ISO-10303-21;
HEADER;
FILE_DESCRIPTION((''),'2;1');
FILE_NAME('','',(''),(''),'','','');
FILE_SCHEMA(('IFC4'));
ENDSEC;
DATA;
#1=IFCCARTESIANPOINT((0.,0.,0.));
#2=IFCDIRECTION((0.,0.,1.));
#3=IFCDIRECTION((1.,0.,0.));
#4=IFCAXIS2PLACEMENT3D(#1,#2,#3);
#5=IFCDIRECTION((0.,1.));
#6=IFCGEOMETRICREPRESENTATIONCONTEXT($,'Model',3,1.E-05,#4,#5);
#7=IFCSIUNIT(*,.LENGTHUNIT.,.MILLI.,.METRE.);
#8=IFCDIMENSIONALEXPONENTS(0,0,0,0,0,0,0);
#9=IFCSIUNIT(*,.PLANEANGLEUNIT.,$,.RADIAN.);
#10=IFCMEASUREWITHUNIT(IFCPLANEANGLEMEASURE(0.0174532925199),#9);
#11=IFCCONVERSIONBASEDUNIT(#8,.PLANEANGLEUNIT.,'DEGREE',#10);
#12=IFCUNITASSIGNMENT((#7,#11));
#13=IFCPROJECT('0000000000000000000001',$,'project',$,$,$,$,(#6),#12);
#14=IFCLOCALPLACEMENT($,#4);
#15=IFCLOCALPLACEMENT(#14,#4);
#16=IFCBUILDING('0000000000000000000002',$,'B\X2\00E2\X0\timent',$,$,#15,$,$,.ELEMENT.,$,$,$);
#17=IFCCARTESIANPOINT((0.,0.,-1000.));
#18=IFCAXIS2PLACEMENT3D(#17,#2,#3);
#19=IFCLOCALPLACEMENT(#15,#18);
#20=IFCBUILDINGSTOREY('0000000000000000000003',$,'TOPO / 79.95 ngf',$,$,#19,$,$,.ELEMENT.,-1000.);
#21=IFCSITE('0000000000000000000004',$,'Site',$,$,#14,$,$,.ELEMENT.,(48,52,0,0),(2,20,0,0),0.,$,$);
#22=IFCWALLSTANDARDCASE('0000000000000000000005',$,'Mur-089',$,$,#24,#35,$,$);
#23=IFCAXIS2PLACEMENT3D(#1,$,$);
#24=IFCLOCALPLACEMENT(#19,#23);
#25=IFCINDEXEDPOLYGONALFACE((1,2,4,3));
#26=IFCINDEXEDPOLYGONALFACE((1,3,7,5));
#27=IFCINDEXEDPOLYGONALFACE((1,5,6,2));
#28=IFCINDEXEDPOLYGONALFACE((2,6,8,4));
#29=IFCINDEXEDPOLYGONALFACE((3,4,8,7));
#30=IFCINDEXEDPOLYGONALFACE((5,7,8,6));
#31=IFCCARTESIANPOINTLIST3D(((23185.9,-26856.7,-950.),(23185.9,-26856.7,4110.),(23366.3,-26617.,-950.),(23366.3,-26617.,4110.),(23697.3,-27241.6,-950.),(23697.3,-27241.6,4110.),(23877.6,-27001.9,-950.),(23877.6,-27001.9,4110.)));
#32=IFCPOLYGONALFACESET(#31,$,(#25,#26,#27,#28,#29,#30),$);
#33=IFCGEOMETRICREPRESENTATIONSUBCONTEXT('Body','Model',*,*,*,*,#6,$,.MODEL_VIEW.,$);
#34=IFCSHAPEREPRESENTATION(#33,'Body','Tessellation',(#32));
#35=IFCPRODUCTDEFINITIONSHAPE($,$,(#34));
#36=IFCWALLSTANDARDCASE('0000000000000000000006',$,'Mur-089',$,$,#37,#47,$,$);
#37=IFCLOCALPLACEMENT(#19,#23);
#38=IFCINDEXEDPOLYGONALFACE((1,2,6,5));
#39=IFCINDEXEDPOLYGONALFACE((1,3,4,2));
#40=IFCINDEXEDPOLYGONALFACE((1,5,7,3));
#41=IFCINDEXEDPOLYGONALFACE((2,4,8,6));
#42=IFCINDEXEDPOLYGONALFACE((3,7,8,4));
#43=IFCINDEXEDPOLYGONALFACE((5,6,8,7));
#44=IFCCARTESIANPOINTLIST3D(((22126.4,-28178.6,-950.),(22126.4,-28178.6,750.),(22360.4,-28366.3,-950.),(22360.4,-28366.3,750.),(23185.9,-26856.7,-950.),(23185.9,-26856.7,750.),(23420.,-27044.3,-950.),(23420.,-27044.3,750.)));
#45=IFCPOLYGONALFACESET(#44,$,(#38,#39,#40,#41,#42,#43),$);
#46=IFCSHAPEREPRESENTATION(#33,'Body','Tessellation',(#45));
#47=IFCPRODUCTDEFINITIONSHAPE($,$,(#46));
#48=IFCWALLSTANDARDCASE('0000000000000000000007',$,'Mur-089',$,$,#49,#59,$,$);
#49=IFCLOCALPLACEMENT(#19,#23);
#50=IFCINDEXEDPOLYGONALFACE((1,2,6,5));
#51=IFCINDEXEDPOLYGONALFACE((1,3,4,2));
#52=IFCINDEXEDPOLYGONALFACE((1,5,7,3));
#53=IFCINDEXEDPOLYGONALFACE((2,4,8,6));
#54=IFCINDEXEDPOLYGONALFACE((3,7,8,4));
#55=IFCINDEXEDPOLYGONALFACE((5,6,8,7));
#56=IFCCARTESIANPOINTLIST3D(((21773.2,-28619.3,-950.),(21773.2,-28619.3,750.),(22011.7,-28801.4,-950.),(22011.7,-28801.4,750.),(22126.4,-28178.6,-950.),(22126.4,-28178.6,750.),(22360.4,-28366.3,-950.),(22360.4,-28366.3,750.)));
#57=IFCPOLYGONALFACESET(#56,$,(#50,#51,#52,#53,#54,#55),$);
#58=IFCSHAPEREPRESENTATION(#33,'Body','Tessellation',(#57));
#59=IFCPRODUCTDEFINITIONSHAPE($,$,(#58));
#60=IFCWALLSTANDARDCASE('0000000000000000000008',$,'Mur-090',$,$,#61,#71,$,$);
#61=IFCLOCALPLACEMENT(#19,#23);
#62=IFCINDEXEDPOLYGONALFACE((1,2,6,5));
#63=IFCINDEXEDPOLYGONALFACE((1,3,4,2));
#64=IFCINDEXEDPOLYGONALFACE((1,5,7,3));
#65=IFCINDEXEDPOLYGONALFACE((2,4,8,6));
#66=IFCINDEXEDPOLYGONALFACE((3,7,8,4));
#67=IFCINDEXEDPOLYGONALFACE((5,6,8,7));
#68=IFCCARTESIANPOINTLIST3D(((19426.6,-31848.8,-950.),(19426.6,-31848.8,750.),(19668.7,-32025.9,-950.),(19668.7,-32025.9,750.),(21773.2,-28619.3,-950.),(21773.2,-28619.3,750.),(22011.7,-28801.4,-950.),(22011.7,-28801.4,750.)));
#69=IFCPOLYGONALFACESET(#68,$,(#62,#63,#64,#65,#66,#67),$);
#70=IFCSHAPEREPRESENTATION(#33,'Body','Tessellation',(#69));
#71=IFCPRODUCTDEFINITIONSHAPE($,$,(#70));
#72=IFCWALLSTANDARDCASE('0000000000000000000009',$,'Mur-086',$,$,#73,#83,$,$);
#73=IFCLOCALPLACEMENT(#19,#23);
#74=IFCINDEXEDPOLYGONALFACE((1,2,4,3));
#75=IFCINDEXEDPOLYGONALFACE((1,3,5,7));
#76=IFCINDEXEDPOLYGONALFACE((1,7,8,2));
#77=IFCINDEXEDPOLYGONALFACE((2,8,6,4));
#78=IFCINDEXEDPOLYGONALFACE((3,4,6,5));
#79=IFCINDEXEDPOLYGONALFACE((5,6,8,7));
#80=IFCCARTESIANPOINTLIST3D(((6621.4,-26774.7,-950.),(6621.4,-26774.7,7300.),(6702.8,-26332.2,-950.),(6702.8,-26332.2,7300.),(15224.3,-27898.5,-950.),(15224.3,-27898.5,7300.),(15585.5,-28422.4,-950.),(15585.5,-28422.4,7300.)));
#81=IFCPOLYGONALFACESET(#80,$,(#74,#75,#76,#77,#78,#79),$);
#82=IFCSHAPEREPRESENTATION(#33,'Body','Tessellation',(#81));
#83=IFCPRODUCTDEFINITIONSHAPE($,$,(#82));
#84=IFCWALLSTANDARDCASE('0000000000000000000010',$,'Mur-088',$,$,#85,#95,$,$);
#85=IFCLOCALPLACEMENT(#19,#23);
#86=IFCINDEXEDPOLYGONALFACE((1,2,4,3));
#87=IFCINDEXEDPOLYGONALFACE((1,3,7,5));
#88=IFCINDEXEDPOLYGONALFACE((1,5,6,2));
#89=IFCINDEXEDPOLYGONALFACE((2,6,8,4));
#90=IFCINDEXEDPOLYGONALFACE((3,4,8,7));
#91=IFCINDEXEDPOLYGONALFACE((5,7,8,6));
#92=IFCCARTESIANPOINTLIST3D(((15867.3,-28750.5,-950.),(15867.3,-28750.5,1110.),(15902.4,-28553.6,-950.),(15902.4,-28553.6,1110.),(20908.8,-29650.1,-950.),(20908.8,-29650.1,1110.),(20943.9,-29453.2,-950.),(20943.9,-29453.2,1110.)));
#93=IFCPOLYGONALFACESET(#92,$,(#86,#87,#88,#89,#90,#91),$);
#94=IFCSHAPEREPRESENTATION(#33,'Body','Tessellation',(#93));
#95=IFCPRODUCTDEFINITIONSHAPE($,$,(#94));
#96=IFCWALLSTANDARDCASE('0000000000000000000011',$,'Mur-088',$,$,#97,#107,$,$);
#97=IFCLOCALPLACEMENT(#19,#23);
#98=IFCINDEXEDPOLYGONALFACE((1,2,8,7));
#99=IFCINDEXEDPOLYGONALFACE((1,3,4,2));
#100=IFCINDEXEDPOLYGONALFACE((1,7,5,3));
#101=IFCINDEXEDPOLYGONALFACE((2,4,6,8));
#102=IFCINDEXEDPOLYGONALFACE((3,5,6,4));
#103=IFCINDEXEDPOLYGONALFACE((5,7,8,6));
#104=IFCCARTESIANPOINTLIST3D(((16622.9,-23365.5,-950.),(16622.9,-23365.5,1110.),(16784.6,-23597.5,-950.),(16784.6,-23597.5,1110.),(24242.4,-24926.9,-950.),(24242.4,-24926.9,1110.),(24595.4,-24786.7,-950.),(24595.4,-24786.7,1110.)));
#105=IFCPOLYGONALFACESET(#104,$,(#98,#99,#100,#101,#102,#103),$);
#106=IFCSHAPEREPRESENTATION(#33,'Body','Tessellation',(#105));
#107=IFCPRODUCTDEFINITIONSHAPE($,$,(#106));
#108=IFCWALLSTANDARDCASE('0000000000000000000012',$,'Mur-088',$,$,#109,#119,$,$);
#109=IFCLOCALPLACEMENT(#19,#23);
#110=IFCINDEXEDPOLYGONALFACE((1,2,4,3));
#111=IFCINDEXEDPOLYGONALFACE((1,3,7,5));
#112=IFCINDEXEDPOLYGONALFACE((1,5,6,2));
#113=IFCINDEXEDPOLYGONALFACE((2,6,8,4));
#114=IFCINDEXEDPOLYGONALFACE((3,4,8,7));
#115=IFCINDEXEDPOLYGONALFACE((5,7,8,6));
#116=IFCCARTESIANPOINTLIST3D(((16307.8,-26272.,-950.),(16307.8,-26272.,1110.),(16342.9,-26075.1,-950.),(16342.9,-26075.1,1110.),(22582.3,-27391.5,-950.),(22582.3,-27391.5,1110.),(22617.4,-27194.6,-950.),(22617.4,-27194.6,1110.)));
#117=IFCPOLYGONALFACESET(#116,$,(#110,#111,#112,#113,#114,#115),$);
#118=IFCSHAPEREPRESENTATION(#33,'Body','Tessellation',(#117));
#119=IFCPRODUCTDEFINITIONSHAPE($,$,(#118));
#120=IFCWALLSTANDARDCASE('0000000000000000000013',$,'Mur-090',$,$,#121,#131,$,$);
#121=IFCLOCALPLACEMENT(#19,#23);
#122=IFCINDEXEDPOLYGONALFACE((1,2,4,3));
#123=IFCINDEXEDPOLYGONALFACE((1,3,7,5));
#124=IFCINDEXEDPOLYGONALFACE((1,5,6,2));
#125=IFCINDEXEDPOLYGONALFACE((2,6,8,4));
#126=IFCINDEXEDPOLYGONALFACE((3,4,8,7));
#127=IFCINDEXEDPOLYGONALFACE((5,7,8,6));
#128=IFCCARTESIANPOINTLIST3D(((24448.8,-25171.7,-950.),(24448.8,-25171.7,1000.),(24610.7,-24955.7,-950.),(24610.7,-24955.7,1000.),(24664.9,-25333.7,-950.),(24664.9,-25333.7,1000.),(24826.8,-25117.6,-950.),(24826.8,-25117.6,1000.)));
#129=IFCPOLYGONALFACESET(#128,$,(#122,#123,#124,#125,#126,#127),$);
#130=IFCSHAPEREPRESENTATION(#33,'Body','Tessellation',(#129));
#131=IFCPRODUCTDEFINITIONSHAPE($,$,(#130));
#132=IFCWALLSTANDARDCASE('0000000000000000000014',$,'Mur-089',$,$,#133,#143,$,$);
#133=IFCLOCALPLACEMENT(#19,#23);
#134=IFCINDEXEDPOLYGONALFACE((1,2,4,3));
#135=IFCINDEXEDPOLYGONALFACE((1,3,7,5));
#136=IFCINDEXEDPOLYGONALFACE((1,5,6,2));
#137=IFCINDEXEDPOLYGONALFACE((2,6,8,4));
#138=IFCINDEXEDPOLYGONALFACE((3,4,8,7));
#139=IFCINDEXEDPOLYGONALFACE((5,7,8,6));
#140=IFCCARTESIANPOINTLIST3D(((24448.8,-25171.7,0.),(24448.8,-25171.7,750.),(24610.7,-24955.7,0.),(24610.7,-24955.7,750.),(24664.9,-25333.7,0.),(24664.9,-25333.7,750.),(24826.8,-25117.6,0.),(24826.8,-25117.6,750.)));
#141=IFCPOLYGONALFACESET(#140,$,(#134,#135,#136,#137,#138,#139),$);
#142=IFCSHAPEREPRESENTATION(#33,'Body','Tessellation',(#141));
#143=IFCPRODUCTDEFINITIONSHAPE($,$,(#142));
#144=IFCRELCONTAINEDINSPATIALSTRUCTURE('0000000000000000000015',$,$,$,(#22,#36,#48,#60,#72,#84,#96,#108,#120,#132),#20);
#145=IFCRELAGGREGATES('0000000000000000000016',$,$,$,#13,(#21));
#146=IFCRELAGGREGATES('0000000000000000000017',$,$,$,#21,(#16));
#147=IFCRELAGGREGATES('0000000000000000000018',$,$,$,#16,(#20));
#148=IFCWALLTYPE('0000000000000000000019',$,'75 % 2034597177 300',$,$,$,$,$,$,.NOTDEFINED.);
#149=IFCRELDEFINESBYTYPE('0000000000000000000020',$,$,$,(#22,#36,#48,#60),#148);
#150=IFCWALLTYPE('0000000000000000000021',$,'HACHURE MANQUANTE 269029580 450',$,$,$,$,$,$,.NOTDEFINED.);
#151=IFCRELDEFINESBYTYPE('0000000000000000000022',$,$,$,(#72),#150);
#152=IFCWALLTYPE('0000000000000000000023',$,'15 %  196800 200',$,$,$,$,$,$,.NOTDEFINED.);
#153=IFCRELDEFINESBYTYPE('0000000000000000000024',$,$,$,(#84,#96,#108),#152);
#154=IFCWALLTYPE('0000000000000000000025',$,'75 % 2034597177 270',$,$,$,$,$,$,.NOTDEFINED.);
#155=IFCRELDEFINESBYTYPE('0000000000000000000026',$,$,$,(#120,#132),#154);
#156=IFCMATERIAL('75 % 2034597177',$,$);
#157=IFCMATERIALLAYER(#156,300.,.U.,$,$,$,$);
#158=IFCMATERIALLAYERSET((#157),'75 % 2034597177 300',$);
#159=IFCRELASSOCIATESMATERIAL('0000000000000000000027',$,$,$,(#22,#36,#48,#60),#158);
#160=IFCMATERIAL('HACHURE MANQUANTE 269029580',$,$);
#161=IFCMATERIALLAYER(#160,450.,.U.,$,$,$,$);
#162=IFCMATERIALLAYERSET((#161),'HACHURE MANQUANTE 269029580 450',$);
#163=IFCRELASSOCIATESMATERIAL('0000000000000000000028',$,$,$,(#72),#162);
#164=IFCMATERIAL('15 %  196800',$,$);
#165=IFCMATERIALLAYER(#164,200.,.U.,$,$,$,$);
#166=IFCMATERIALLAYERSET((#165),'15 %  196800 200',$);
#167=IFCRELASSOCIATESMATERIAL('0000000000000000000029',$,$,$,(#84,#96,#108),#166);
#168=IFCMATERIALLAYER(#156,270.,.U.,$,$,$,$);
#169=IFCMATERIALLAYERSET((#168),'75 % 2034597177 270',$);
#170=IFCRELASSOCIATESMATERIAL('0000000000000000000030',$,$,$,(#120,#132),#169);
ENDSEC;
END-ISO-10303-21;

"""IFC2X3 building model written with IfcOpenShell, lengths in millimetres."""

from ifc_helpers import new_model, entity, si_unit, converted_unit, direction, frame, origin_with_axes, place, context, subcontext, project, spatial, polyline, outline, extrude, material, layer, layer_set, layer_usage, type_object, element, save


model = new_model("IFC2X3")

# Units and contexts
model_context = context("Model", 3, precision=1e-05, world=origin_with_axes(), true_north=direction((0.0, 1.0)))
body_context = subcontext(model_context, "Body", "Model", "MODEL_VIEW")
ifc_project = project(units=[si_unit("LENGTHUNIT", "METRE", prefix="MILLI"), converted_unit("PLANEANGLEUNIT", "DEGREE", entity("IfcPlaneAngleMeasure", 0.0174532925199), si_unit("PLANEANGLEUNIT", "RADIAN"), dimensions=[0, 0, 0, 0, 0, 0, 0])], contexts=[model_context])

# Site, building, storey
site_placement = place(None, origin_with_axes())
site = spatial("IfcSite", under=ifc_project, at=site_placement, Name="Site", CompositionType="ELEMENT", RefLatitude=(48, 52, 0, 0), RefLongitude=(2, 20, 0, 0), RefElevation=0.0)
building_placement = place(site_placement, origin_with_axes())
building = spatial("IfcBuilding", under=site, at=building_placement, Name="Bâtiment", CompositionType="ELEMENT")
storey_placement = place(building_placement, frame((0.0, 0.0, -1000.0), z_axis=(0.0, 0.0, 1.0), x_axis=(1.0, 0.0, 0.0)))
storey = spatial("IfcBuildingStorey", under=building, at=storey_placement, Name="TOPO / 79.95 ngf", CompositionType="ELEMENT", Elevation=-1000.0)

# Walls
ifc_material_1 = material(Name="75 % 2034597177")
ifc_layer_1 = layer(ifc_material_1, 300.0, ventilated="UNKNOWN")
ifc_layer_set_1 = layer_set([ifc_layer_1], Name="75 % 2034597177 300")
ifc_layer_usage_1 = layer_usage(ifc_layer_set_1, "AXIS2", "POSITIVE", -300.0)
wall_type_1 = type_object("IfcWallType", Name="75 % 2034597177 300", PredefinedType="NOTDEFINED")
wall_1_placement = place(storey_placement, frame((23366.3, -26617.0, -950.0), z_axis=(0.0, 0.0, 1.0), x_axis=(0.799009, -0.60132, 0.0)))
element("IfcWallStandardCase", 1, at=wall_1_placement, inside=storey, type_object=wall_type_1, material=ifc_layer_usage_1, Name="Mur-089", context=body_context, shape_type="SweptSolid", body=[
    extrude(outline(polyline([(0.0, -300.0), (640.0, -300.0), (640.0, 0.0), (0.0, 0.0), (0.0, -300.0)])), origin_with_axes(), (0.0, 0.0, 1.0), 5060.0),
])
ifc_layer_usage_2 = layer_usage(ifc_layer_set_1, "AXIS2", "NEGATIVE", 300.0)
wall_2_placement = place(storey_placement, frame((23185.9, -26856.7, -950.0), z_axis=(0.0, 0.0, 1.0), x_axis=(-0.625413, -0.780294, 0.0)))
element("IfcWallStandardCase", 2, at=wall_2_placement, inside=storey, type_object=wall_type_1, material=ifc_layer_usage_2, Name="Mur-089", context=body_context, shape_type="SweptSolid", body=[
    extrude(outline(polyline([(0.0, 0.0), (1694.1, 0.0), (1694.1, 300.0), (0.0, 300.0), (0.0, 0.0)])), origin_with_axes(), (0.0, 0.0, 1.0), 1700.0),
])
ifc_layer_usage_3 = layer_usage(ifc_layer_set_1, "AXIS2", "NEGATIVE", 300.0)
wall_3_placement = place(storey_placement, frame((22126.4, -28178.6, -950.0), z_axis=(0.0, 0.0, 1.0), x_axis=(-0.625413, -0.780294, 0.0)))
element("IfcWallStandardCase", 3, at=wall_3_placement, inside=storey, type_object=wall_type_1, material=ifc_layer_usage_3, Name="Mur-089", context=body_context, shape_type="SweptSolid", body=[
    extrude(outline(polyline([(0.0, 0.0), (564.7, 0.0), (557.6, 300.0), (0.0, 300.0), (0.0, 0.0)])), origin_with_axes(), (0.0, 0.0, 1.0), 1700.0),
])
ifc_layer_usage_4 = layer_usage(ifc_layer_set_1, "AXIS2", "NEGATIVE", 300.0)
wall_4_placement = place(storey_placement, frame((21773.2, -28619.3, -950.0), z_axis=(0.0, 0.0, 1.0), x_axis=(-0.587821, -0.808991, 0.0)))
element("IfcWallStandardCase", 4, at=wall_4_placement, inside=storey, type_object=wall_type_1, material=ifc_layer_usage_4, Name="Mur-090", context=body_context, shape_type="SweptSolid", body=[
    extrude(outline(polyline([(0.0, 0.0), (3992.0, 0.0), (3993.0, 300.0), (7.1, 300.0), (0.0, 0.0)])), origin_with_axes(), (0.0, 0.0, 1.0), 1700.0),
])
ifc_material_2 = material(Name="HACHURE MANQUANTE 269029580")
ifc_layer_2 = layer(ifc_material_2, 450.0, ventilated="UNKNOWN")
ifc_layer_set_2 = layer_set([ifc_layer_2], Name="HACHURE MANQUANTE 269029580 450")
wall_type_2 = type_object("IfcWallType", Name="HACHURE MANQUANTE 269029580 450", PredefinedType="NOTDEFINED")
ifc_layer_usage_5 = layer_usage(ifc_layer_set_2, "AXIS2", "POSITIVE", -450.0)
wall_5_placement = place(storey_placement, frame((15585.5, -28422.4, -950.0), z_axis=(0.0, 0.0, 1.0), x_axis=(-0.983524, 0.18078, 0.0)))
element("IfcWallStandardCase", 5, at=wall_5_placement, inside=storey, type_object=wall_type_2, material=ifc_layer_usage_5, Name="Mur-086", context=body_context, shape_type="SweptSolid", body=[
    extrude(outline(polyline([(450.0, -450.0), (9114.2, -450.0), (9114.2, 0.0), (0.0, 0.0), (450.0, -450.0)])), origin_with_axes(), (0.0, 0.0, 1.0), 8250.0),
])
ifc_material_3 = material(Name="15 %  196800")
ifc_layer_3 = layer(ifc_material_3, 200.0, ventilated="UNKNOWN")
ifc_layer_set_3 = layer_set([ifc_layer_3], Name="15 %  196800 200")
ifc_layer_usage_6 = layer_usage(ifc_layer_set_3, "AXIS2", "POSITIVE", -200.0)
wall_type_3 = type_object("IfcWallType", Name="15 %  196800 200", PredefinedType="NOTDEFINED")
wall_6_placement = place(storey_placement, frame((15902.4, -28553.6, -950.0), z_axis=(0.0, 0.0, 1.0), x_axis=(0.984451, -0.175658, 0.0)))
element("IfcWallStandardCase", 6, at=wall_6_placement, inside=storey, type_object=wall_type_3, material=ifc_layer_usage_6, Name="Mur-088", context=body_context, shape_type="SweptSolid", body=[
    extrude(outline(polyline([(0.0, -200.0), (5121.1, -200.0), (5121.1, 0.0), (0.0, 0.0), (0.0, -200.0)])), origin_with_axes(), (0.0, 0.0, 1.0), 2060.0),
])
ifc_layer_usage_7 = layer_usage(ifc_layer_set_3, "AXIS2", "POSITIVE", -200.0)
wall_7_placement = place(storey_placement, frame((16819.8, -23400.6, -950.0), z_axis=(0.0, 0.0, 1.0), x_axis=(0.98448, -0.175499, 0.0)))
element("IfcWallStandardCase", 7, at=wall_7_placement, inside=storey, type_object=wall_type_3, material=ifc_layer_usage_7, Name="Mur-088", context=body_context, shape_type="SweptSolid", body=[
    extrude(outline(polyline([(0.0, -200.0), (7575.3, -200.0), (7898.2, 0.0), (-200.0, 0.0), (0.0, -200.0)])), origin_with_axes(), (0.0, 0.0, 1.0), 2060.0),
])
ifc_layer_usage_8 = layer_usage(ifc_layer_set_3, "AXIS2", "POSITIVE", -200.0)
wall_8_placement = place(storey_placement, frame((16342.9, -26075.1, -950.0), z_axis=(0.0, 0.0, 1.0), x_axis=(0.984451, -0.175658, 0.0)))
element("IfcWallStandardCase", 8, at=wall_8_placement, inside=storey, type_object=wall_type_3, material=ifc_layer_usage_8, Name="Mur-088", context=body_context, shape_type="SweptSolid", body=[
    extrude(outline(polyline([(0.0, -200.0), (6373.6, -200.0), (6373.6, 0.0), (0.0, 0.0), (0.0, -200.0)])), origin_with_axes(), (0.0, 0.0, 1.0), 2060.0),
])
ifc_layer_4 = layer(ifc_material_1, 270.0, ventilated="UNKNOWN")
ifc_layer_set_4 = layer_set([ifc_layer_4], Name="75 % 2034597177 270")
ifc_layer_usage_9 = layer_usage(ifc_layer_set_4, "AXIS2", "POSITIVE", -270.0)
wall_type_4 = type_object("IfcWallType", Name="75 % 2034597177 270", PredefinedType="NOTDEFINED")
wall_9_placement = place(storey_placement, frame((24610.7, -24955.7, -950.0), z_axis=(0.0, 0.0, 1.0), x_axis=(0.800255, -0.599659, 0.0)))
element("IfcWallStandardCase", 9, at=wall_9_placement, inside=storey, type_object=wall_type_4, material=ifc_layer_usage_9, Name="Mur-090", context=body_context, shape_type="SweptSolid", body=[
    extrude(outline(polyline([(0.0, -270.0), (270.0, -270.0), (270.0, 0.0), (0.0, 0.0), (0.0, -270.0)])), origin_with_axes(), (0.0, 0.0, 1.0), 1950.0),
])
ifc_layer_usage_10 = layer_usage(ifc_layer_set_4, "AXIS2", "POSITIVE", -270.0)
wall_10_placement = place(storey_placement, frame((24610.7, -24955.7, 0.0), z_axis=(0.0, 0.0, 1.0), x_axis=(0.800255, -0.599659, 0.0)))
element("IfcWallStandardCase", 10, at=wall_10_placement, inside=storey, type_object=wall_type_4, material=ifc_layer_usage_10, Name="Mur-089", context=body_context, shape_type="SweptSolid", body=[
    extrude(outline(polyline([(0.0, -270.0), (270.0, -270.0), (270.0, 0.0), (0.0, 0.0), (0.0, -270.0)])), origin_with_axes(), (0.0, 0.0, 1.0), 750.0),
])

save(model, "model.ifc")
